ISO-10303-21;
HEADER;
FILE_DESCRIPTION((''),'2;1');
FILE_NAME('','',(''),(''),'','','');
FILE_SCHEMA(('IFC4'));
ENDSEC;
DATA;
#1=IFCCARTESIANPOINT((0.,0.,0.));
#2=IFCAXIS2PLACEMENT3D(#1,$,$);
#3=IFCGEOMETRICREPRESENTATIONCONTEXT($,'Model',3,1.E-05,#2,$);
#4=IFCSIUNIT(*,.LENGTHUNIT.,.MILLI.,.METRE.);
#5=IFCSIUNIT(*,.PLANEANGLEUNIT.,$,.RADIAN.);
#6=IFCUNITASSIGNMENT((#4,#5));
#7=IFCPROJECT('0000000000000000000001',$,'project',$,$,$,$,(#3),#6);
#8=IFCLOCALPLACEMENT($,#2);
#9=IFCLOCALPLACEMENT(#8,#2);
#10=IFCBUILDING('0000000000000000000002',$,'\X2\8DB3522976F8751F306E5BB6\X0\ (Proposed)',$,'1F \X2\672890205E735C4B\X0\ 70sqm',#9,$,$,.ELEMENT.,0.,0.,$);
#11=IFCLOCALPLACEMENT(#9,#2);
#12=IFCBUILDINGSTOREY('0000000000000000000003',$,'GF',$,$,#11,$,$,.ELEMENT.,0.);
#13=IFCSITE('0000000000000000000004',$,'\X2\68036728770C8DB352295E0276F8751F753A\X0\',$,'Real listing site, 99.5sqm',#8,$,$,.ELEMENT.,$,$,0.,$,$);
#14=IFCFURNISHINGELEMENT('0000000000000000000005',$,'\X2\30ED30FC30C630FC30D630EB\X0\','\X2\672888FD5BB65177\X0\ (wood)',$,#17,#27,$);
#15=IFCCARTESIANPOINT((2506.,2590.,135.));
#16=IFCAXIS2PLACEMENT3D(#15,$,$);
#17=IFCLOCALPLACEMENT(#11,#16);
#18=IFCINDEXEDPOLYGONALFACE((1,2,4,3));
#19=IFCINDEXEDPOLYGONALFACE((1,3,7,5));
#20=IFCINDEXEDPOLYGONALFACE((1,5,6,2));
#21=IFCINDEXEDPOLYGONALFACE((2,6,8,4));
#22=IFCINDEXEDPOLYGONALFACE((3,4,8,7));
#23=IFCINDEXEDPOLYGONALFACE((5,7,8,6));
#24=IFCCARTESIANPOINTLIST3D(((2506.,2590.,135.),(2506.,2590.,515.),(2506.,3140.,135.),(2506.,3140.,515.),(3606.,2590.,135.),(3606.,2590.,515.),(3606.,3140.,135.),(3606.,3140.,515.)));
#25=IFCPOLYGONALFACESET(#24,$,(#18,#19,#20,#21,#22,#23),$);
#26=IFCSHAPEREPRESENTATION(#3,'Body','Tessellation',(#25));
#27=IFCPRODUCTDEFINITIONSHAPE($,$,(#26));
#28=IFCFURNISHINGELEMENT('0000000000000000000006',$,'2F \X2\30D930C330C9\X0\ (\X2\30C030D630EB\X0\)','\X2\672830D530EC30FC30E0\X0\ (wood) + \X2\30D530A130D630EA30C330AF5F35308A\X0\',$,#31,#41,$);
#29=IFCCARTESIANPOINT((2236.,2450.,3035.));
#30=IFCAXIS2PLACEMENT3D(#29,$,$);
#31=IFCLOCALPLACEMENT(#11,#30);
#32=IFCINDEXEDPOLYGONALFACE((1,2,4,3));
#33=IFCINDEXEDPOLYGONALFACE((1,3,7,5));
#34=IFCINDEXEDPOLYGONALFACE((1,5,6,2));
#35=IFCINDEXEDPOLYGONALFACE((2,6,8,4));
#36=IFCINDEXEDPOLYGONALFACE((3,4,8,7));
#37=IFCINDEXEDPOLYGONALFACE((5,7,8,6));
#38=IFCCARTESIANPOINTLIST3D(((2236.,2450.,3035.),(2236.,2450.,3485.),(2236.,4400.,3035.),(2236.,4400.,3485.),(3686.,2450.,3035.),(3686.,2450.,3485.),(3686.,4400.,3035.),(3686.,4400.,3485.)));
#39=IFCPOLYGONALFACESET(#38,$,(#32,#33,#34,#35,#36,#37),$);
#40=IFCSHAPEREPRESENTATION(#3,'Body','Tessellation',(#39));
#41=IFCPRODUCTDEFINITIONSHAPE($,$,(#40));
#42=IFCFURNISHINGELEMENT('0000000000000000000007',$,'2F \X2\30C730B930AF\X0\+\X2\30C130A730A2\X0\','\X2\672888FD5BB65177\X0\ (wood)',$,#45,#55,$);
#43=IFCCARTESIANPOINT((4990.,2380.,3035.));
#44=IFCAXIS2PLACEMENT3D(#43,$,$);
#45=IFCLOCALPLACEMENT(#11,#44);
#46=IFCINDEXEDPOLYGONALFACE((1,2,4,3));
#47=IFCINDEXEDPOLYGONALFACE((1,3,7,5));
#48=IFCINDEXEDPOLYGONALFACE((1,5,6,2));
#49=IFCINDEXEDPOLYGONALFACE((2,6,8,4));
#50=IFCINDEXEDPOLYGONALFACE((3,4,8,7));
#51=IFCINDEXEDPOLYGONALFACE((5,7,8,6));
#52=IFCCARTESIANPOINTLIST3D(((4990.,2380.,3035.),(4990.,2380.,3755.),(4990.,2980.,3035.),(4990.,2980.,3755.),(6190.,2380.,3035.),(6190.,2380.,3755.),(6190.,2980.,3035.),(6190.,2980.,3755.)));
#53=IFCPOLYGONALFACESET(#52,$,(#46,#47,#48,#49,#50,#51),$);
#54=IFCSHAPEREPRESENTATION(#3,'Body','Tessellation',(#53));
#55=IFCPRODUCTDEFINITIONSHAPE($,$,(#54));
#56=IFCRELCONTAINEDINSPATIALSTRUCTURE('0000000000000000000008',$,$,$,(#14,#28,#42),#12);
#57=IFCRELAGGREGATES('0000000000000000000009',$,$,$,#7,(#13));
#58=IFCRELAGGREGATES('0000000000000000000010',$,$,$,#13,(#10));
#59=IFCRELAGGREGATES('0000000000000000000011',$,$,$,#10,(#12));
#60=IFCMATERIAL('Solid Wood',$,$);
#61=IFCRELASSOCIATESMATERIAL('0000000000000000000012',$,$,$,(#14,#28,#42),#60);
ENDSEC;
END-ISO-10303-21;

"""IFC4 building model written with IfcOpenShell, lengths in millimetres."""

from ifc_helpers import new_model, si_unit, frame, frame_2d, origin, place, context, project, spatial, rectangle, extrude, material, element, save


model = new_model("IFC4")

# Units and contexts
model_context = context("Model", 3, precision=1e-05, world=origin())
ifc_project = project(units=[si_unit("LENGTHUNIT", "METRE", prefix="MILLI"), si_unit("PLANEANGLEUNIT", "RADIAN")], contexts=[model_context])

# Site, building, storey
site_placement = place(None, origin())
site = spatial("IfcSite", under=ifc_project, at=site_placement, Name="栃木県足利市相生町", ObjectType="Real listing site, 99.5sqm", CompositionType="ELEMENT", RefElevation=0.0)
building_placement = place(site_placement, origin())
building = spatial("IfcBuilding", under=site, at=building_placement, Name="足利相生の家 (Proposed)", ObjectType="1F 木造平屋 70sqm", CompositionType="ELEMENT", ElevationOfRefHeight=0.0, ElevationOfTerrain=0.0)
storey_placement = place(building_placement, origin())
storey = spatial("IfcBuildingStorey", under=building, at=storey_placement, Name="GF", CompositionType="ELEMENT", Elevation=0.0)

# Shared definitions
ifc_material_1 = material(Name="Solid Wood")

# Furnishing elements
furnishing_1_placement = place(storey_placement, frame((2506.0, 2590.0, 135.0)))
element("IfcFurnishingElement", 1, at=furnishing_1_placement, inside=storey, material=ifc_material_1, Name="ローテーブル", Description="木製家具 (wood)", context=model_context, shape_type="SweptSolid", body=[
    extrude(rectangle(XDim=1100.0, YDim=550.0, at=frame_2d((550.0, 275.0))), frame((2506.0, 2590.0, 135.0)), (0.0, 0.0, 1.0), 380.0),
])
furnishing_2_placement = place(storey_placement, frame((2236.0, 2450.0, 3035.0)))
element("IfcFurnishingElement", 2, at=furnishing_2_placement, inside=storey, material=ifc_material_1, Name="2F ベッド (ダブル)", Description="木フレーム (wood) + ファブリック張り", context=model_context, shape_type="SweptSolid", body=[
    extrude(rectangle(XDim=1450.0, YDim=1950.0, at=frame_2d((725.0, 975.0))), frame((2236.0, 2450.0, 3035.0)), (0.0, 0.0, 1.0), 450.0),
])
furnishing_3_placement = place(storey_placement, frame((4990.0, 2380.0, 3035.0)))
element("IfcFurnishingElement", 3, at=furnishing_3_placement, inside=storey, material=ifc_material_1, Name="2F デスク+チェア", Description="木製家具 (wood)", context=model_context, shape_type="SweptSolid", body=[
    extrude(rectangle(XDim=1200.0, YDim=600.0, at=frame_2d((600.0, 300.0))), frame((4990.0, 2380.0, 3035.0)), (0.0, 0.0, 1.0), 720.0),
])

save(model, "model.ifc")
